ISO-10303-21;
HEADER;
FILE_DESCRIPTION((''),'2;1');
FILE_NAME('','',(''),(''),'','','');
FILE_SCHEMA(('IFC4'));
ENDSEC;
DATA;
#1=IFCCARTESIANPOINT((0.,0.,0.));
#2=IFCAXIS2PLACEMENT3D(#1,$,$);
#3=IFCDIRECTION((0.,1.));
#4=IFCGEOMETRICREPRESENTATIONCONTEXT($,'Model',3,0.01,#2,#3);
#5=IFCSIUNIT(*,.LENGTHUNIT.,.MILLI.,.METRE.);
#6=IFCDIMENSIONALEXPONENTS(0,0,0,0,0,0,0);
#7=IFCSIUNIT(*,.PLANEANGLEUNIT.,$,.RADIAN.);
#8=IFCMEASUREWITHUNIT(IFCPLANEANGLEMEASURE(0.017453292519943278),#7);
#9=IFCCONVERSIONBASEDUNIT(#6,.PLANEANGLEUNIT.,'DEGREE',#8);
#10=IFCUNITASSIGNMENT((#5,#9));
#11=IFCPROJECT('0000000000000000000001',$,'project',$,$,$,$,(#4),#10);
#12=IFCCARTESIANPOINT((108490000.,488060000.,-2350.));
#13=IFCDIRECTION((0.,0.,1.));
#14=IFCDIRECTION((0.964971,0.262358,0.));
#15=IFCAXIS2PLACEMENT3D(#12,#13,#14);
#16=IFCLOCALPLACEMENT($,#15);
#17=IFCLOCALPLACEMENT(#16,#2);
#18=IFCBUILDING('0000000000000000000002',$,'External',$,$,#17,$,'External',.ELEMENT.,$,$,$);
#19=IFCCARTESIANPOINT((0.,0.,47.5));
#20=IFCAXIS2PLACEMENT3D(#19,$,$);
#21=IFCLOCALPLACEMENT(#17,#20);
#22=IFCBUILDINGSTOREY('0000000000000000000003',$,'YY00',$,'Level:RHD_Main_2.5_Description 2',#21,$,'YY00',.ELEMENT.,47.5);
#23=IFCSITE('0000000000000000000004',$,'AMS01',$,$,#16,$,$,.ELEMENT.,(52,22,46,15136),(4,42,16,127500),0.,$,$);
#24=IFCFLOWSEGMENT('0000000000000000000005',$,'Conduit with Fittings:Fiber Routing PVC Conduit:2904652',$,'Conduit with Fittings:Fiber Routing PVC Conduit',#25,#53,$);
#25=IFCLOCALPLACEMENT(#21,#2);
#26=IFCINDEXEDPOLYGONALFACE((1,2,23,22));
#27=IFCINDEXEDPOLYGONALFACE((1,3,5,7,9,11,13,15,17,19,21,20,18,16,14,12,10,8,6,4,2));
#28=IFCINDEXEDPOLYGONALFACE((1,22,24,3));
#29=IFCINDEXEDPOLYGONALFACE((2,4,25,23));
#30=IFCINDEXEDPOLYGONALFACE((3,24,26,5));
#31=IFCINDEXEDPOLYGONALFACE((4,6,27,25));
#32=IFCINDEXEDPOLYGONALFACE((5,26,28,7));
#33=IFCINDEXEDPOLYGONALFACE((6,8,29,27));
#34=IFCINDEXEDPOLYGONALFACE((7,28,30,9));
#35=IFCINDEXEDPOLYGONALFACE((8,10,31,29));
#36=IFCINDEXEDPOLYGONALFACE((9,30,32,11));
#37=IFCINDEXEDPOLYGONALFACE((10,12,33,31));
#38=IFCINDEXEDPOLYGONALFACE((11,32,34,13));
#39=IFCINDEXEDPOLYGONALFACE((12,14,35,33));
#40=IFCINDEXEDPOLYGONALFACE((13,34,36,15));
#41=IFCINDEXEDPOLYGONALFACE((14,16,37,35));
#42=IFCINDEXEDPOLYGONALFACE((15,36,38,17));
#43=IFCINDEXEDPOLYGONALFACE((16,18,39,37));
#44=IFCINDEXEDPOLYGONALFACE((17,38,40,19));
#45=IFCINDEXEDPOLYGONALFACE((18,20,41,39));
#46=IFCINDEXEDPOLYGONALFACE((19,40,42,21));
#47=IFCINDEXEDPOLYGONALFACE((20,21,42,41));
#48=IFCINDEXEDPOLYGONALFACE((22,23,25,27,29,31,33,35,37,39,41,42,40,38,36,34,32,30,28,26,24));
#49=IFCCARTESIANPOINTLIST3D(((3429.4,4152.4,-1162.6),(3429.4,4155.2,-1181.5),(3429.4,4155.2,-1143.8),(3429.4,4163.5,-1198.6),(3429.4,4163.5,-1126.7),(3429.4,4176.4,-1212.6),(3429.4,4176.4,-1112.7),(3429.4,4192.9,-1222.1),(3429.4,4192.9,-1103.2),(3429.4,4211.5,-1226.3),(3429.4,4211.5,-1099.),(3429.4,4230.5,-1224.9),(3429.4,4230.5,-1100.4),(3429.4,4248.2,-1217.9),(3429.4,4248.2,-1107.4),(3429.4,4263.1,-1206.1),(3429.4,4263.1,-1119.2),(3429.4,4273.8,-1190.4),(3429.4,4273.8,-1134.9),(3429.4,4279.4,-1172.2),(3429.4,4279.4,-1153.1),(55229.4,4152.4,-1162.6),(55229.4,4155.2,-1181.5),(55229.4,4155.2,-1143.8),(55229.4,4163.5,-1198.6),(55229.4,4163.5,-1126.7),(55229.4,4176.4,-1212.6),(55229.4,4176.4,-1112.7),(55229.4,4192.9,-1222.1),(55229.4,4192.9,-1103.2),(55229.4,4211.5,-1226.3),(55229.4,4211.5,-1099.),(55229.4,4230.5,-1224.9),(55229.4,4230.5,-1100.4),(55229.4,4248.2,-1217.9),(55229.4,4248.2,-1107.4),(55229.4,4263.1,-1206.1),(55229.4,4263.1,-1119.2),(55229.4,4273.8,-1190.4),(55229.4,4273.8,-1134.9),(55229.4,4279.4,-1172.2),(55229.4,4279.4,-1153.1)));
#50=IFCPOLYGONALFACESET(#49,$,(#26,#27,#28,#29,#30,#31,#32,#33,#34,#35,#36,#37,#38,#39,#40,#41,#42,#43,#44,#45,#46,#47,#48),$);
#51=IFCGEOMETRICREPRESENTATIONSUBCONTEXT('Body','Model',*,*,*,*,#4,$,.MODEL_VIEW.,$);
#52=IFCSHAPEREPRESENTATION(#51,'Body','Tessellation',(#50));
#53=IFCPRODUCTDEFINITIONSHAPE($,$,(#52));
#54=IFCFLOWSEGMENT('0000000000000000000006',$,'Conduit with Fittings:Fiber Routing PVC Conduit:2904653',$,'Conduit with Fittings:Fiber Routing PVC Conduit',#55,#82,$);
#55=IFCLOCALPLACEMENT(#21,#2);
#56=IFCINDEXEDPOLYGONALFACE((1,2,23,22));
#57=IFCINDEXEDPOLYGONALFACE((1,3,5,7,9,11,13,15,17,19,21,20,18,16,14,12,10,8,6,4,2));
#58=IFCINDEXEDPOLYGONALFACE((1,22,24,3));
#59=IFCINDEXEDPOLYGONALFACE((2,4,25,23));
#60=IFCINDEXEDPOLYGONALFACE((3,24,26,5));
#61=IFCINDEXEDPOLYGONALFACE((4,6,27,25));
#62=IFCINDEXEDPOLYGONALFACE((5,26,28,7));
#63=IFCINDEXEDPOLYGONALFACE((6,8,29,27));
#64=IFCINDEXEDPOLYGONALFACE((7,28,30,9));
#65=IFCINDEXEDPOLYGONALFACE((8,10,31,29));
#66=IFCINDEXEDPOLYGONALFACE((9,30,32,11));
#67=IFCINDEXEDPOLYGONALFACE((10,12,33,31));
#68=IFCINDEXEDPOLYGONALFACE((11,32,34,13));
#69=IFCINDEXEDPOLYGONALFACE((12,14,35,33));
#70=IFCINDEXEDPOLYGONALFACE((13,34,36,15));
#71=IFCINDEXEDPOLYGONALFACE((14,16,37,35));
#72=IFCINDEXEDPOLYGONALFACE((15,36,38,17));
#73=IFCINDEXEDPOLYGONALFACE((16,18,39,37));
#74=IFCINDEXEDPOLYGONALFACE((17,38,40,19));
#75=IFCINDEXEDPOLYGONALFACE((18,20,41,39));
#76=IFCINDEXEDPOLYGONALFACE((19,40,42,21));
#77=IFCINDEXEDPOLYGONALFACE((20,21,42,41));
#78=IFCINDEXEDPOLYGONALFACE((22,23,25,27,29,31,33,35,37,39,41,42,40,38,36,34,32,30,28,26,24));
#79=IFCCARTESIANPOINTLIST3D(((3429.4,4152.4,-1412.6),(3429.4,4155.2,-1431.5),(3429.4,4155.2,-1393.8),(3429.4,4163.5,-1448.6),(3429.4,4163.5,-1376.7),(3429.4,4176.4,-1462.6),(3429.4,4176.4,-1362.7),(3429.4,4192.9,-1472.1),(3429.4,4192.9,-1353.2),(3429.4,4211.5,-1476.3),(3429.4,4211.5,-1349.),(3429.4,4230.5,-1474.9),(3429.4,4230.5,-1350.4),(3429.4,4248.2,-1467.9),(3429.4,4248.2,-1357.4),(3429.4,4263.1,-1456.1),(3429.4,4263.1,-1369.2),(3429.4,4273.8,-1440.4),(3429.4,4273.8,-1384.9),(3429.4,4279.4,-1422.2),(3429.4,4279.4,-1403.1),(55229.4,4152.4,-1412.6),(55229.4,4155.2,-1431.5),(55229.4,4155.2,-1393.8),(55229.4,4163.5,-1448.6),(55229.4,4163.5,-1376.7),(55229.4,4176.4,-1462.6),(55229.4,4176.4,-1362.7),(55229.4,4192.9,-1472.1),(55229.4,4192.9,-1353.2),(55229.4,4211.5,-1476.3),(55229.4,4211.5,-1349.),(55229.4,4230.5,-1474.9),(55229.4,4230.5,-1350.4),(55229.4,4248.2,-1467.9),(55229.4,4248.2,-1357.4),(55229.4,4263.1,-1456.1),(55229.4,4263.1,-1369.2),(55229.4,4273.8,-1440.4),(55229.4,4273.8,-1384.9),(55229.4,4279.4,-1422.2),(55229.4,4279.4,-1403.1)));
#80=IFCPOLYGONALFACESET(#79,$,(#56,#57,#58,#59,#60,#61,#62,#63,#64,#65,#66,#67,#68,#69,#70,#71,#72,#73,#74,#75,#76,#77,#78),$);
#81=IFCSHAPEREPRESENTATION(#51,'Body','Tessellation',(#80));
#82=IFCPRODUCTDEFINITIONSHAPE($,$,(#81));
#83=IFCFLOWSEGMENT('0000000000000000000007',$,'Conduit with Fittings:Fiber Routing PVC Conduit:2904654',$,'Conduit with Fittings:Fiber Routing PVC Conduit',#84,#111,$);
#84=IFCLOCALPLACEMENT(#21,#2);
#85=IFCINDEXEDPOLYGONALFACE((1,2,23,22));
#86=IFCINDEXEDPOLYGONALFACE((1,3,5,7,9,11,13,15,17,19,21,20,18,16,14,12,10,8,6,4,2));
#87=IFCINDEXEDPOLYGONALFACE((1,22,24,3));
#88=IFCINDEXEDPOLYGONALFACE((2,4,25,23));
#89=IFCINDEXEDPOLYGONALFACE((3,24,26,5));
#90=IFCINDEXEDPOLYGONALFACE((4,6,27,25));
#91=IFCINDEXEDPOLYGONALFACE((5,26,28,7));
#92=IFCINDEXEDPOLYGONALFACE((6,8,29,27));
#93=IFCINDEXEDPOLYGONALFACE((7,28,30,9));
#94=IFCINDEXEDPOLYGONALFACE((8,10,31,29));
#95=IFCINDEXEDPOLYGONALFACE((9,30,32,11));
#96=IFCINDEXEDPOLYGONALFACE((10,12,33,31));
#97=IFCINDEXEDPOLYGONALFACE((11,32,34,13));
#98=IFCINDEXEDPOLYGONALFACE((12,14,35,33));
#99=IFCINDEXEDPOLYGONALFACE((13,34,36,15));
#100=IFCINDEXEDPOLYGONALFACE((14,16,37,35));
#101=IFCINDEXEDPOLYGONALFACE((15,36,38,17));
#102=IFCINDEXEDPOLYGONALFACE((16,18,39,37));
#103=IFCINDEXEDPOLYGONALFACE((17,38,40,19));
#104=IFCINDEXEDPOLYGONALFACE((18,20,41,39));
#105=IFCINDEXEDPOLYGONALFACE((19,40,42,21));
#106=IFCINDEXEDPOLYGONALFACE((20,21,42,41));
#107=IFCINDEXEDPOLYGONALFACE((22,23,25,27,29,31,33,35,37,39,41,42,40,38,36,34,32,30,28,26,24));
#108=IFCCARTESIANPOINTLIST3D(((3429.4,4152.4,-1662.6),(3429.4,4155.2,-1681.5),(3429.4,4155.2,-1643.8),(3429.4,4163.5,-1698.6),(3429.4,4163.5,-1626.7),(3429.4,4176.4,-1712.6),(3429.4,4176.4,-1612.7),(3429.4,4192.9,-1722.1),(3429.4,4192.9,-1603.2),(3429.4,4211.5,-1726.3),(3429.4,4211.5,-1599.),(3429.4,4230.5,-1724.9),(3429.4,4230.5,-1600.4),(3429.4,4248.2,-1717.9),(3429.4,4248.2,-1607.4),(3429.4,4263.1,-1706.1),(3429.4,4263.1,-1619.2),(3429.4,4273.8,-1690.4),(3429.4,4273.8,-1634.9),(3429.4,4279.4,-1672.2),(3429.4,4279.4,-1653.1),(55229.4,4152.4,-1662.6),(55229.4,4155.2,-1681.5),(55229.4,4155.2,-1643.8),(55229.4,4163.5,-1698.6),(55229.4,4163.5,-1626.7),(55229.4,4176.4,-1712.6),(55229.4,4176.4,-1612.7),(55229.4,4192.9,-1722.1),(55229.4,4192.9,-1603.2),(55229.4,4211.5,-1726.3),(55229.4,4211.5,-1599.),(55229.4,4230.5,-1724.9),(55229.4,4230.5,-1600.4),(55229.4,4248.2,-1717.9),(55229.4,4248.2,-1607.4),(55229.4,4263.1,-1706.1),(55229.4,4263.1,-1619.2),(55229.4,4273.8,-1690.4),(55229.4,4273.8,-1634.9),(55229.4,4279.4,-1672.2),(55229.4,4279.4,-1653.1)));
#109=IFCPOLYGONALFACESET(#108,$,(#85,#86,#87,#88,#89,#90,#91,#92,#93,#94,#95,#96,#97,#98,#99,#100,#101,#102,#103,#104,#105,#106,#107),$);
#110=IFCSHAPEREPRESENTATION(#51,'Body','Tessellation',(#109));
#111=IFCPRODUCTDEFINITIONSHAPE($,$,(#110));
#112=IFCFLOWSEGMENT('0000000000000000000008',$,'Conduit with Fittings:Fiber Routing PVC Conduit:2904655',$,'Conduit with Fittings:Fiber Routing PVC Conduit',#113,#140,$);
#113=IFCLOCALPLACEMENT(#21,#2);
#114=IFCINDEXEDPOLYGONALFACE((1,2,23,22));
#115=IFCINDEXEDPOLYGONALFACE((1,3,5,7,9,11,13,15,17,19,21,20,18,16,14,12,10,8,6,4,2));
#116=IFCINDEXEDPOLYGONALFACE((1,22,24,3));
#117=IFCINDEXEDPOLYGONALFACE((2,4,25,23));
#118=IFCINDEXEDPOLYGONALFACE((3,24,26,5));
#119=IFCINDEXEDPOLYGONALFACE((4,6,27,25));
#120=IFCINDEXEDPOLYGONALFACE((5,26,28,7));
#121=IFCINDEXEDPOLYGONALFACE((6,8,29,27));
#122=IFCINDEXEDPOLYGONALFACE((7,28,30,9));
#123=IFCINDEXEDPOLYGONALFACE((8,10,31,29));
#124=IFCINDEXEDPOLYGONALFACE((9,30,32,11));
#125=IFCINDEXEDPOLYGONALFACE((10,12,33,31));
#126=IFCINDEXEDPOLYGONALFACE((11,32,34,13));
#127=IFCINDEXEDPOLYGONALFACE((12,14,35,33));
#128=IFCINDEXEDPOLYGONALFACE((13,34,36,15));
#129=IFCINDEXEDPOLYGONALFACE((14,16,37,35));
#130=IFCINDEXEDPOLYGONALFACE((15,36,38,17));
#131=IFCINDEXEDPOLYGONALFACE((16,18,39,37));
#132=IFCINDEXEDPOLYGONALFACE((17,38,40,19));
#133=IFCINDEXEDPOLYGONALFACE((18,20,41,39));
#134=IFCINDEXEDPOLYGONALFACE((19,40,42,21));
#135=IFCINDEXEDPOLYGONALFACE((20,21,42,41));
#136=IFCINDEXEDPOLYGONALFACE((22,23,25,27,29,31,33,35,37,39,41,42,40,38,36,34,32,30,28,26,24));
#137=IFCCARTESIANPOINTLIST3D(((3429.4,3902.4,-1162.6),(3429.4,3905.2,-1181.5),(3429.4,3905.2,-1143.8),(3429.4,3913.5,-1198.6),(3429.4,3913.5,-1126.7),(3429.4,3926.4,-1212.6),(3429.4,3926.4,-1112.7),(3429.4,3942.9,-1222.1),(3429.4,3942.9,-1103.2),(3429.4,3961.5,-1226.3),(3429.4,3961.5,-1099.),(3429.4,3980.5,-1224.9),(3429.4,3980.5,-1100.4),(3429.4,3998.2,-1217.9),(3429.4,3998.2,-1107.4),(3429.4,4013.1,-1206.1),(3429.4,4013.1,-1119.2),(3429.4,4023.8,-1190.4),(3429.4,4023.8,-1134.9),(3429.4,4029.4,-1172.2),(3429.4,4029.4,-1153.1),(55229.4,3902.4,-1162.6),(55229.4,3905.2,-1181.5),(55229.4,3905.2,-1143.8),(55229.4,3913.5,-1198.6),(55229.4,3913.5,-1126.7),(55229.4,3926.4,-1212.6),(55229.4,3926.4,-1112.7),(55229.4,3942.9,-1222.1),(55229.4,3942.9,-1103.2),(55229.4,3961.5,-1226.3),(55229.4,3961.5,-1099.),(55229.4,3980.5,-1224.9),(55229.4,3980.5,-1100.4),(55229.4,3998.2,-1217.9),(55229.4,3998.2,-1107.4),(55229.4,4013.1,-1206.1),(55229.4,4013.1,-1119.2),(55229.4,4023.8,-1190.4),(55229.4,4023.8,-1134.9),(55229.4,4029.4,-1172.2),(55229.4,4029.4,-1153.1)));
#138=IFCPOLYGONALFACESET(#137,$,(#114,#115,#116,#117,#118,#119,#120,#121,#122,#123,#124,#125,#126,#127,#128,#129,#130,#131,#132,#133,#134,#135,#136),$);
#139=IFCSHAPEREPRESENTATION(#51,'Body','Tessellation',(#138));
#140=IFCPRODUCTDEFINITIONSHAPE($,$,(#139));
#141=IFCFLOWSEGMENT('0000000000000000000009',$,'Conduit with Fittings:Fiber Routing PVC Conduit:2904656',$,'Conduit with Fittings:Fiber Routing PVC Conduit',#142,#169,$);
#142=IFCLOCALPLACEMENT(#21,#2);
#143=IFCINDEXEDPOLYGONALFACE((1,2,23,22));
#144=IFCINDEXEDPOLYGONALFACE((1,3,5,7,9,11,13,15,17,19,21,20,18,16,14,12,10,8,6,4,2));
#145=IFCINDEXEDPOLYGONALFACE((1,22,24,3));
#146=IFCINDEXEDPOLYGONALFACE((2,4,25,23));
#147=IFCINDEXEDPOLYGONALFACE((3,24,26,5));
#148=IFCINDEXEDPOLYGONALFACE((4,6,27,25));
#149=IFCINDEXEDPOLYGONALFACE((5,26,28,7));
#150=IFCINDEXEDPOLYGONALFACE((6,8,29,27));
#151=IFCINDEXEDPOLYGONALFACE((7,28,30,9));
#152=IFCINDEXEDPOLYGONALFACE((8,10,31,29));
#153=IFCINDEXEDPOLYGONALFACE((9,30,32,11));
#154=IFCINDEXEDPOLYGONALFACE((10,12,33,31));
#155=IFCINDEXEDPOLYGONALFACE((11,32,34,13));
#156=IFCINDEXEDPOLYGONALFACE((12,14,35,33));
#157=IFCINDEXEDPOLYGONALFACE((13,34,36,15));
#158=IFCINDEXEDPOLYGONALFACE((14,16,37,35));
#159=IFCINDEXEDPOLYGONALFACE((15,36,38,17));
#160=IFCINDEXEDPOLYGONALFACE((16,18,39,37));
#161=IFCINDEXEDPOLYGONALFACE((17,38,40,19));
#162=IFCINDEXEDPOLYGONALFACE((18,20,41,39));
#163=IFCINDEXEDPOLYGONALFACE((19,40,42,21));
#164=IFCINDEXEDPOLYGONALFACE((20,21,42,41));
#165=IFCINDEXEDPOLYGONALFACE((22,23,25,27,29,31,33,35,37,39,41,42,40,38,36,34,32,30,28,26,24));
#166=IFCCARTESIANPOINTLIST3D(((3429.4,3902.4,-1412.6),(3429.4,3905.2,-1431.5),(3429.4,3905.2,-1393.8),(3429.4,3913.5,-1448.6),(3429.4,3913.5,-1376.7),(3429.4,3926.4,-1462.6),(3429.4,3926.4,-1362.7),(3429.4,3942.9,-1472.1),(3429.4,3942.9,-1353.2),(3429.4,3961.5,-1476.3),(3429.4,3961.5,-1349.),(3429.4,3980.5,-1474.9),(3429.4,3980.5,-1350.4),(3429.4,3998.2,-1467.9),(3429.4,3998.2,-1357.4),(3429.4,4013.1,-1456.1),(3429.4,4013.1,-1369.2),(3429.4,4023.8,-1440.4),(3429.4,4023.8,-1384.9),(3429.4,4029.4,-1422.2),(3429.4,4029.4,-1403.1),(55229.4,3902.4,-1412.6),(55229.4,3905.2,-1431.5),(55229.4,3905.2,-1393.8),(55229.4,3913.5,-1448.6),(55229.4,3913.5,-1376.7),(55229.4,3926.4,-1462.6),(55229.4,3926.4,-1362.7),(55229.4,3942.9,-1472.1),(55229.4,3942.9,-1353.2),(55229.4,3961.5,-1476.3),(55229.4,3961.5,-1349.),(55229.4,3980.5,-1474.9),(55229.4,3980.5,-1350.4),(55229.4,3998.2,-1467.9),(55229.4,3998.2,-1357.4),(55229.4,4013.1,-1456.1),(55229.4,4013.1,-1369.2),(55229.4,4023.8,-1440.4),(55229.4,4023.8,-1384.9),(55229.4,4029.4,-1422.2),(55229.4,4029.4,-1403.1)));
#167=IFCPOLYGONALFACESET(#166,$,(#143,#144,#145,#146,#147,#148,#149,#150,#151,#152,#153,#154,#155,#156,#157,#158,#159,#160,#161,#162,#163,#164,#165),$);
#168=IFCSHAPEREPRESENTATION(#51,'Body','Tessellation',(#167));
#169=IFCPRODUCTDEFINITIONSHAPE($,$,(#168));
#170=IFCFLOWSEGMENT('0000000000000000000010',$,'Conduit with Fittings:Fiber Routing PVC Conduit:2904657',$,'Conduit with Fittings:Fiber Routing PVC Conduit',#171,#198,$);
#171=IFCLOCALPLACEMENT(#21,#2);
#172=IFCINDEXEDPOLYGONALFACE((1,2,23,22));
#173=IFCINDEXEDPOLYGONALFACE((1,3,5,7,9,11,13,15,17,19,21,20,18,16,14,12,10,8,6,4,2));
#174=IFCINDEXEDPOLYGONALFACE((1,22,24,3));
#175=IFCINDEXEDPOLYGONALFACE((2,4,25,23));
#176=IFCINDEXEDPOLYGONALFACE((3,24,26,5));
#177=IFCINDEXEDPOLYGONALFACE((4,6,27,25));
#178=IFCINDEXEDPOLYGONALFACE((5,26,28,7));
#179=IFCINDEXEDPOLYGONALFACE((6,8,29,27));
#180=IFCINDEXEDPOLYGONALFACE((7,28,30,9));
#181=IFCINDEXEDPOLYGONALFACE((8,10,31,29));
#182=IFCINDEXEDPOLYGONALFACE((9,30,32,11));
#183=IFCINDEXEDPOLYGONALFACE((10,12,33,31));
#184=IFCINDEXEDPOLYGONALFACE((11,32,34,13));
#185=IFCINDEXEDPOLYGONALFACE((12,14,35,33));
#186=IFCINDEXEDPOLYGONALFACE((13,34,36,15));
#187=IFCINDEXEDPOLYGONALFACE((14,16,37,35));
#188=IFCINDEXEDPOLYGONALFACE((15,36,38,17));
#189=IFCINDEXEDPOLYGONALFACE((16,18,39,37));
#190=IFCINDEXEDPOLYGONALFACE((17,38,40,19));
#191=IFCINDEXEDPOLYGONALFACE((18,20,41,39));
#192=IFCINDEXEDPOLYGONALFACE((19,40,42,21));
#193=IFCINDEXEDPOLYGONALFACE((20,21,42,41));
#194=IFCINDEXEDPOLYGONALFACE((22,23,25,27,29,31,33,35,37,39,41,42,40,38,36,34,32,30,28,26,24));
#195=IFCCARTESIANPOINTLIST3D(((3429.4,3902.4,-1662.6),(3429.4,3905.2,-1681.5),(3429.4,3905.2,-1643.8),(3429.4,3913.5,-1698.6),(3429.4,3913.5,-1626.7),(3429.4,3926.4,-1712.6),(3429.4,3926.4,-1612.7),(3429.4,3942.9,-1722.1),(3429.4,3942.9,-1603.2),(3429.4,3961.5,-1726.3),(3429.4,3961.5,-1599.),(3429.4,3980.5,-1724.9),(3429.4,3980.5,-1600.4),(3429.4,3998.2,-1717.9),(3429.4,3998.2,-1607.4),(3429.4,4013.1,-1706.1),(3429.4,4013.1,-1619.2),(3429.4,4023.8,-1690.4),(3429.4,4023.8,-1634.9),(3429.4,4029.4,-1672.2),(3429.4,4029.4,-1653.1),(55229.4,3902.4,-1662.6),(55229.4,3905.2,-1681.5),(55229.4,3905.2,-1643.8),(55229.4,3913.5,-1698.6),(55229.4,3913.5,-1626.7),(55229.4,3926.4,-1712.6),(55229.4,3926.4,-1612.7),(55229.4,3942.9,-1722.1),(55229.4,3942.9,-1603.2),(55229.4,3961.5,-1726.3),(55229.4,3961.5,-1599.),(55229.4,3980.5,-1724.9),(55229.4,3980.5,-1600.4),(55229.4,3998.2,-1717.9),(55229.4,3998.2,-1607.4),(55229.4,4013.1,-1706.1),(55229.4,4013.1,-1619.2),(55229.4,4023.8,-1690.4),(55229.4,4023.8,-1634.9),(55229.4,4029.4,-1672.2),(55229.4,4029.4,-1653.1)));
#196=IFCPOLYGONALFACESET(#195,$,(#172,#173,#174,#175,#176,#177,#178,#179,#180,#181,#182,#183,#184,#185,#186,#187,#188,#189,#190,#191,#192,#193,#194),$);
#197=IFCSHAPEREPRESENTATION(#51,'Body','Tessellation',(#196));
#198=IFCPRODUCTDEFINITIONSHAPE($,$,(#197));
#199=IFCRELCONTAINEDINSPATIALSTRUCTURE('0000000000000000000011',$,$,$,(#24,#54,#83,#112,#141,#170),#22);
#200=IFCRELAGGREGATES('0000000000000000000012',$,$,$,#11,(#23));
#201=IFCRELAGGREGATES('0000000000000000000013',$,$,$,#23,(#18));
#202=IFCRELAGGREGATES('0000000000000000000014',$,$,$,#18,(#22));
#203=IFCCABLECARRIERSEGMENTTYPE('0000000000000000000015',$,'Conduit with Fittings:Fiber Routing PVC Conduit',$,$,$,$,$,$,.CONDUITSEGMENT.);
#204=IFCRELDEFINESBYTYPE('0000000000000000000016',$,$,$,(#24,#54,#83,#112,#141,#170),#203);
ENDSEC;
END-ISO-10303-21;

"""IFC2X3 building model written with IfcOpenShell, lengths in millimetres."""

from ifc_helpers import new_model, entity, si_unit, converted_unit, direction, frame, frame_2d, origin, origin_2d_with_axis, place, context, subcontext, project, spatial, circle, extrude, type_object, element, save


model = new_model("IFC2X3")

# Units and contexts
model_context = context("Model", 3, precision=0.01, world=origin(), true_north=direction((0.0, 1.0)))
body_context = subcontext(model_context, "Body", "Model", "MODEL_VIEW")
ifc_project = project(units=[si_unit("LENGTHUNIT", "METRE", prefix="MILLI"), converted_unit("PLANEANGLEUNIT", "DEGREE", entity("IfcPlaneAngleMeasure", 0.017453292519943278), si_unit("PLANEANGLEUNIT", "RADIAN"), dimensions=[0, 0, 0, 0, 0, 0, 0])], contexts=[model_context])

# Site, building, storey
site_placement = place(None, frame((108490000.0, 488060000.0, -2350.0), z_axis=(0.0, 0.0, 1.0), x_axis=(0.964971, 0.262358, 0.0)))
site = spatial("IfcSite", under=ifc_project, at=site_placement, Name="AMS01", CompositionType="ELEMENT", RefLatitude=(52, 22, 46, 15136), RefLongitude=(4, 42, 16, 127500), RefElevation=0.0)
building_placement = place(site_placement, origin())
building = spatial("IfcBuilding", under=site, at=building_placement, Name="External", LongName="External", CompositionType="ELEMENT")
storey_placement = place(building_placement, frame((0.0, 0.0, 47.5)))
storey = spatial("IfcBuildingStorey", under=building, at=storey_placement, Name="YY00", ObjectType="Level:RHD_Main_2.5_Description 2", LongName="YY00", CompositionType="ELEMENT", Elevation=47.5)

# Flow segments
cable_carrier_segment_type = type_object("IfcCableCarrierSegmentType", Name="Conduit with Fittings:Fiber Routing PVC Conduit", PredefinedType="CONDUITSEGMENT")
flow_segment_1_placement = place(storey_placement, origin())
element("IfcFlowSegment", 1, at=flow_segment_1_placement, inside=storey, type_object=cable_carrier_segment_type, Name="Conduit with Fittings:Fiber Routing PVC Conduit:2904652", ObjectType="Conduit with Fittings:Fiber Routing PVC Conduit", context=body_context, shape_type="SweptSolid", body=[
    extrude(circle(Radius=63.9, at=origin_2d_with_axis()), frame((3429.4, 4216.3, -1162.6), z_axis=(1.0, 0.0, 0.0), x_axis=(0.0, -1.0, 0.0)), (0.0, 0.0, 1.0), 51800.0),
])
flow_segment_2_placement = place(storey_placement, origin())
element("IfcFlowSegment", 2, at=flow_segment_2_placement, inside=storey, type_object=cable_carrier_segment_type, Name="Conduit with Fittings:Fiber Routing PVC Conduit:2904653", ObjectType="Conduit with Fittings:Fiber Routing PVC Conduit", context=body_context, shape_type="SweptSolid", body=[
    extrude(circle(Radius=63.9, at=frame_2d((0.0, 0.0), x_axis=(1.0, 0.0))), frame((3429.4, 4216.3, -1412.6), z_axis=(1.0, 0.0, 0.0), x_axis=(0.0, -1.0, 0.0)), (0.0, 0.0, 1.0), 51800.0),
])
flow_segment_3_placement = place(storey_placement, origin())
element("IfcFlowSegment", 3, at=flow_segment_3_placement, inside=storey, type_object=cable_carrier_segment_type, Name="Conduit with Fittings:Fiber Routing PVC Conduit:2904654", ObjectType="Conduit with Fittings:Fiber Routing PVC Conduit", context=body_context, shape_type="SweptSolid", body=[
    extrude(circle(Radius=63.9, at=frame_2d((0.0, 0.0), x_axis=(1.0, 0.0))), frame((3429.4, 4216.3, -1662.6), z_axis=(1.0, 0.0, 0.0), x_axis=(0.0, -1.0, 0.0)), (0.0, 0.0, 1.0), 51800.0),
])
flow_segment_4_placement = place(storey_placement, origin())
element("IfcFlowSegment", 4, at=flow_segment_4_placement, inside=storey, type_object=cable_carrier_segment_type, Name="Conduit with Fittings:Fiber Routing PVC Conduit:2904655", ObjectType="Conduit with Fittings:Fiber Routing PVC Conduit", context=body_context, shape_type="SweptSolid", body=[
    extrude(circle(Radius=63.9, at=origin_2d_with_axis()), frame((3429.4, 3966.3, -1162.6), z_axis=(1.0, 0.0, 0.0), x_axis=(0.0, -1.0, 0.0)), (0.0, 0.0, 1.0), 51800.0),
])
flow_segment_5_placement = place(storey_placement, origin())
element("IfcFlowSegment", 5, at=flow_segment_5_placement, inside=storey, type_object=cable_carrier_segment_type, Name="Conduit with Fittings:Fiber Routing PVC Conduit:2904656", ObjectType="Conduit with Fittings:Fiber Routing PVC Conduit", context=body_context, shape_type="SweptSolid", body=[
    extrude(circle(Radius=63.9, at=origin_2d_with_axis()), frame((3429.4, 3966.3, -1412.6), z_axis=(1.0, 0.0, 0.0), x_axis=(0.0, -1.0, 0.0)), (0.0, 0.0, 1.0), 51800.0),
])
flow_segment_6_placement = place(storey_placement, origin())
element("IfcFlowSegment", 6, at=flow_segment_6_placement, inside=storey, type_object=cable_carrier_segment_type, Name="Conduit with Fittings:Fiber Routing PVC Conduit:2904657", ObjectType="Conduit with Fittings:Fiber Routing PVC Conduit", context=body_context, shape_type="SweptSolid", body=[
    extrude(circle(Radius=63.9, at=frame_2d((0.0, 0.0), x_axis=(1.0, 0.0))), frame((3429.4, 3966.3, -1662.6), z_axis=(1.0, 0.0, 0.0), x_axis=(0.0, -1.0, 0.0)), (0.0, 0.0, 1.0), 51800.0),
])

save(model, "model.ifc")
